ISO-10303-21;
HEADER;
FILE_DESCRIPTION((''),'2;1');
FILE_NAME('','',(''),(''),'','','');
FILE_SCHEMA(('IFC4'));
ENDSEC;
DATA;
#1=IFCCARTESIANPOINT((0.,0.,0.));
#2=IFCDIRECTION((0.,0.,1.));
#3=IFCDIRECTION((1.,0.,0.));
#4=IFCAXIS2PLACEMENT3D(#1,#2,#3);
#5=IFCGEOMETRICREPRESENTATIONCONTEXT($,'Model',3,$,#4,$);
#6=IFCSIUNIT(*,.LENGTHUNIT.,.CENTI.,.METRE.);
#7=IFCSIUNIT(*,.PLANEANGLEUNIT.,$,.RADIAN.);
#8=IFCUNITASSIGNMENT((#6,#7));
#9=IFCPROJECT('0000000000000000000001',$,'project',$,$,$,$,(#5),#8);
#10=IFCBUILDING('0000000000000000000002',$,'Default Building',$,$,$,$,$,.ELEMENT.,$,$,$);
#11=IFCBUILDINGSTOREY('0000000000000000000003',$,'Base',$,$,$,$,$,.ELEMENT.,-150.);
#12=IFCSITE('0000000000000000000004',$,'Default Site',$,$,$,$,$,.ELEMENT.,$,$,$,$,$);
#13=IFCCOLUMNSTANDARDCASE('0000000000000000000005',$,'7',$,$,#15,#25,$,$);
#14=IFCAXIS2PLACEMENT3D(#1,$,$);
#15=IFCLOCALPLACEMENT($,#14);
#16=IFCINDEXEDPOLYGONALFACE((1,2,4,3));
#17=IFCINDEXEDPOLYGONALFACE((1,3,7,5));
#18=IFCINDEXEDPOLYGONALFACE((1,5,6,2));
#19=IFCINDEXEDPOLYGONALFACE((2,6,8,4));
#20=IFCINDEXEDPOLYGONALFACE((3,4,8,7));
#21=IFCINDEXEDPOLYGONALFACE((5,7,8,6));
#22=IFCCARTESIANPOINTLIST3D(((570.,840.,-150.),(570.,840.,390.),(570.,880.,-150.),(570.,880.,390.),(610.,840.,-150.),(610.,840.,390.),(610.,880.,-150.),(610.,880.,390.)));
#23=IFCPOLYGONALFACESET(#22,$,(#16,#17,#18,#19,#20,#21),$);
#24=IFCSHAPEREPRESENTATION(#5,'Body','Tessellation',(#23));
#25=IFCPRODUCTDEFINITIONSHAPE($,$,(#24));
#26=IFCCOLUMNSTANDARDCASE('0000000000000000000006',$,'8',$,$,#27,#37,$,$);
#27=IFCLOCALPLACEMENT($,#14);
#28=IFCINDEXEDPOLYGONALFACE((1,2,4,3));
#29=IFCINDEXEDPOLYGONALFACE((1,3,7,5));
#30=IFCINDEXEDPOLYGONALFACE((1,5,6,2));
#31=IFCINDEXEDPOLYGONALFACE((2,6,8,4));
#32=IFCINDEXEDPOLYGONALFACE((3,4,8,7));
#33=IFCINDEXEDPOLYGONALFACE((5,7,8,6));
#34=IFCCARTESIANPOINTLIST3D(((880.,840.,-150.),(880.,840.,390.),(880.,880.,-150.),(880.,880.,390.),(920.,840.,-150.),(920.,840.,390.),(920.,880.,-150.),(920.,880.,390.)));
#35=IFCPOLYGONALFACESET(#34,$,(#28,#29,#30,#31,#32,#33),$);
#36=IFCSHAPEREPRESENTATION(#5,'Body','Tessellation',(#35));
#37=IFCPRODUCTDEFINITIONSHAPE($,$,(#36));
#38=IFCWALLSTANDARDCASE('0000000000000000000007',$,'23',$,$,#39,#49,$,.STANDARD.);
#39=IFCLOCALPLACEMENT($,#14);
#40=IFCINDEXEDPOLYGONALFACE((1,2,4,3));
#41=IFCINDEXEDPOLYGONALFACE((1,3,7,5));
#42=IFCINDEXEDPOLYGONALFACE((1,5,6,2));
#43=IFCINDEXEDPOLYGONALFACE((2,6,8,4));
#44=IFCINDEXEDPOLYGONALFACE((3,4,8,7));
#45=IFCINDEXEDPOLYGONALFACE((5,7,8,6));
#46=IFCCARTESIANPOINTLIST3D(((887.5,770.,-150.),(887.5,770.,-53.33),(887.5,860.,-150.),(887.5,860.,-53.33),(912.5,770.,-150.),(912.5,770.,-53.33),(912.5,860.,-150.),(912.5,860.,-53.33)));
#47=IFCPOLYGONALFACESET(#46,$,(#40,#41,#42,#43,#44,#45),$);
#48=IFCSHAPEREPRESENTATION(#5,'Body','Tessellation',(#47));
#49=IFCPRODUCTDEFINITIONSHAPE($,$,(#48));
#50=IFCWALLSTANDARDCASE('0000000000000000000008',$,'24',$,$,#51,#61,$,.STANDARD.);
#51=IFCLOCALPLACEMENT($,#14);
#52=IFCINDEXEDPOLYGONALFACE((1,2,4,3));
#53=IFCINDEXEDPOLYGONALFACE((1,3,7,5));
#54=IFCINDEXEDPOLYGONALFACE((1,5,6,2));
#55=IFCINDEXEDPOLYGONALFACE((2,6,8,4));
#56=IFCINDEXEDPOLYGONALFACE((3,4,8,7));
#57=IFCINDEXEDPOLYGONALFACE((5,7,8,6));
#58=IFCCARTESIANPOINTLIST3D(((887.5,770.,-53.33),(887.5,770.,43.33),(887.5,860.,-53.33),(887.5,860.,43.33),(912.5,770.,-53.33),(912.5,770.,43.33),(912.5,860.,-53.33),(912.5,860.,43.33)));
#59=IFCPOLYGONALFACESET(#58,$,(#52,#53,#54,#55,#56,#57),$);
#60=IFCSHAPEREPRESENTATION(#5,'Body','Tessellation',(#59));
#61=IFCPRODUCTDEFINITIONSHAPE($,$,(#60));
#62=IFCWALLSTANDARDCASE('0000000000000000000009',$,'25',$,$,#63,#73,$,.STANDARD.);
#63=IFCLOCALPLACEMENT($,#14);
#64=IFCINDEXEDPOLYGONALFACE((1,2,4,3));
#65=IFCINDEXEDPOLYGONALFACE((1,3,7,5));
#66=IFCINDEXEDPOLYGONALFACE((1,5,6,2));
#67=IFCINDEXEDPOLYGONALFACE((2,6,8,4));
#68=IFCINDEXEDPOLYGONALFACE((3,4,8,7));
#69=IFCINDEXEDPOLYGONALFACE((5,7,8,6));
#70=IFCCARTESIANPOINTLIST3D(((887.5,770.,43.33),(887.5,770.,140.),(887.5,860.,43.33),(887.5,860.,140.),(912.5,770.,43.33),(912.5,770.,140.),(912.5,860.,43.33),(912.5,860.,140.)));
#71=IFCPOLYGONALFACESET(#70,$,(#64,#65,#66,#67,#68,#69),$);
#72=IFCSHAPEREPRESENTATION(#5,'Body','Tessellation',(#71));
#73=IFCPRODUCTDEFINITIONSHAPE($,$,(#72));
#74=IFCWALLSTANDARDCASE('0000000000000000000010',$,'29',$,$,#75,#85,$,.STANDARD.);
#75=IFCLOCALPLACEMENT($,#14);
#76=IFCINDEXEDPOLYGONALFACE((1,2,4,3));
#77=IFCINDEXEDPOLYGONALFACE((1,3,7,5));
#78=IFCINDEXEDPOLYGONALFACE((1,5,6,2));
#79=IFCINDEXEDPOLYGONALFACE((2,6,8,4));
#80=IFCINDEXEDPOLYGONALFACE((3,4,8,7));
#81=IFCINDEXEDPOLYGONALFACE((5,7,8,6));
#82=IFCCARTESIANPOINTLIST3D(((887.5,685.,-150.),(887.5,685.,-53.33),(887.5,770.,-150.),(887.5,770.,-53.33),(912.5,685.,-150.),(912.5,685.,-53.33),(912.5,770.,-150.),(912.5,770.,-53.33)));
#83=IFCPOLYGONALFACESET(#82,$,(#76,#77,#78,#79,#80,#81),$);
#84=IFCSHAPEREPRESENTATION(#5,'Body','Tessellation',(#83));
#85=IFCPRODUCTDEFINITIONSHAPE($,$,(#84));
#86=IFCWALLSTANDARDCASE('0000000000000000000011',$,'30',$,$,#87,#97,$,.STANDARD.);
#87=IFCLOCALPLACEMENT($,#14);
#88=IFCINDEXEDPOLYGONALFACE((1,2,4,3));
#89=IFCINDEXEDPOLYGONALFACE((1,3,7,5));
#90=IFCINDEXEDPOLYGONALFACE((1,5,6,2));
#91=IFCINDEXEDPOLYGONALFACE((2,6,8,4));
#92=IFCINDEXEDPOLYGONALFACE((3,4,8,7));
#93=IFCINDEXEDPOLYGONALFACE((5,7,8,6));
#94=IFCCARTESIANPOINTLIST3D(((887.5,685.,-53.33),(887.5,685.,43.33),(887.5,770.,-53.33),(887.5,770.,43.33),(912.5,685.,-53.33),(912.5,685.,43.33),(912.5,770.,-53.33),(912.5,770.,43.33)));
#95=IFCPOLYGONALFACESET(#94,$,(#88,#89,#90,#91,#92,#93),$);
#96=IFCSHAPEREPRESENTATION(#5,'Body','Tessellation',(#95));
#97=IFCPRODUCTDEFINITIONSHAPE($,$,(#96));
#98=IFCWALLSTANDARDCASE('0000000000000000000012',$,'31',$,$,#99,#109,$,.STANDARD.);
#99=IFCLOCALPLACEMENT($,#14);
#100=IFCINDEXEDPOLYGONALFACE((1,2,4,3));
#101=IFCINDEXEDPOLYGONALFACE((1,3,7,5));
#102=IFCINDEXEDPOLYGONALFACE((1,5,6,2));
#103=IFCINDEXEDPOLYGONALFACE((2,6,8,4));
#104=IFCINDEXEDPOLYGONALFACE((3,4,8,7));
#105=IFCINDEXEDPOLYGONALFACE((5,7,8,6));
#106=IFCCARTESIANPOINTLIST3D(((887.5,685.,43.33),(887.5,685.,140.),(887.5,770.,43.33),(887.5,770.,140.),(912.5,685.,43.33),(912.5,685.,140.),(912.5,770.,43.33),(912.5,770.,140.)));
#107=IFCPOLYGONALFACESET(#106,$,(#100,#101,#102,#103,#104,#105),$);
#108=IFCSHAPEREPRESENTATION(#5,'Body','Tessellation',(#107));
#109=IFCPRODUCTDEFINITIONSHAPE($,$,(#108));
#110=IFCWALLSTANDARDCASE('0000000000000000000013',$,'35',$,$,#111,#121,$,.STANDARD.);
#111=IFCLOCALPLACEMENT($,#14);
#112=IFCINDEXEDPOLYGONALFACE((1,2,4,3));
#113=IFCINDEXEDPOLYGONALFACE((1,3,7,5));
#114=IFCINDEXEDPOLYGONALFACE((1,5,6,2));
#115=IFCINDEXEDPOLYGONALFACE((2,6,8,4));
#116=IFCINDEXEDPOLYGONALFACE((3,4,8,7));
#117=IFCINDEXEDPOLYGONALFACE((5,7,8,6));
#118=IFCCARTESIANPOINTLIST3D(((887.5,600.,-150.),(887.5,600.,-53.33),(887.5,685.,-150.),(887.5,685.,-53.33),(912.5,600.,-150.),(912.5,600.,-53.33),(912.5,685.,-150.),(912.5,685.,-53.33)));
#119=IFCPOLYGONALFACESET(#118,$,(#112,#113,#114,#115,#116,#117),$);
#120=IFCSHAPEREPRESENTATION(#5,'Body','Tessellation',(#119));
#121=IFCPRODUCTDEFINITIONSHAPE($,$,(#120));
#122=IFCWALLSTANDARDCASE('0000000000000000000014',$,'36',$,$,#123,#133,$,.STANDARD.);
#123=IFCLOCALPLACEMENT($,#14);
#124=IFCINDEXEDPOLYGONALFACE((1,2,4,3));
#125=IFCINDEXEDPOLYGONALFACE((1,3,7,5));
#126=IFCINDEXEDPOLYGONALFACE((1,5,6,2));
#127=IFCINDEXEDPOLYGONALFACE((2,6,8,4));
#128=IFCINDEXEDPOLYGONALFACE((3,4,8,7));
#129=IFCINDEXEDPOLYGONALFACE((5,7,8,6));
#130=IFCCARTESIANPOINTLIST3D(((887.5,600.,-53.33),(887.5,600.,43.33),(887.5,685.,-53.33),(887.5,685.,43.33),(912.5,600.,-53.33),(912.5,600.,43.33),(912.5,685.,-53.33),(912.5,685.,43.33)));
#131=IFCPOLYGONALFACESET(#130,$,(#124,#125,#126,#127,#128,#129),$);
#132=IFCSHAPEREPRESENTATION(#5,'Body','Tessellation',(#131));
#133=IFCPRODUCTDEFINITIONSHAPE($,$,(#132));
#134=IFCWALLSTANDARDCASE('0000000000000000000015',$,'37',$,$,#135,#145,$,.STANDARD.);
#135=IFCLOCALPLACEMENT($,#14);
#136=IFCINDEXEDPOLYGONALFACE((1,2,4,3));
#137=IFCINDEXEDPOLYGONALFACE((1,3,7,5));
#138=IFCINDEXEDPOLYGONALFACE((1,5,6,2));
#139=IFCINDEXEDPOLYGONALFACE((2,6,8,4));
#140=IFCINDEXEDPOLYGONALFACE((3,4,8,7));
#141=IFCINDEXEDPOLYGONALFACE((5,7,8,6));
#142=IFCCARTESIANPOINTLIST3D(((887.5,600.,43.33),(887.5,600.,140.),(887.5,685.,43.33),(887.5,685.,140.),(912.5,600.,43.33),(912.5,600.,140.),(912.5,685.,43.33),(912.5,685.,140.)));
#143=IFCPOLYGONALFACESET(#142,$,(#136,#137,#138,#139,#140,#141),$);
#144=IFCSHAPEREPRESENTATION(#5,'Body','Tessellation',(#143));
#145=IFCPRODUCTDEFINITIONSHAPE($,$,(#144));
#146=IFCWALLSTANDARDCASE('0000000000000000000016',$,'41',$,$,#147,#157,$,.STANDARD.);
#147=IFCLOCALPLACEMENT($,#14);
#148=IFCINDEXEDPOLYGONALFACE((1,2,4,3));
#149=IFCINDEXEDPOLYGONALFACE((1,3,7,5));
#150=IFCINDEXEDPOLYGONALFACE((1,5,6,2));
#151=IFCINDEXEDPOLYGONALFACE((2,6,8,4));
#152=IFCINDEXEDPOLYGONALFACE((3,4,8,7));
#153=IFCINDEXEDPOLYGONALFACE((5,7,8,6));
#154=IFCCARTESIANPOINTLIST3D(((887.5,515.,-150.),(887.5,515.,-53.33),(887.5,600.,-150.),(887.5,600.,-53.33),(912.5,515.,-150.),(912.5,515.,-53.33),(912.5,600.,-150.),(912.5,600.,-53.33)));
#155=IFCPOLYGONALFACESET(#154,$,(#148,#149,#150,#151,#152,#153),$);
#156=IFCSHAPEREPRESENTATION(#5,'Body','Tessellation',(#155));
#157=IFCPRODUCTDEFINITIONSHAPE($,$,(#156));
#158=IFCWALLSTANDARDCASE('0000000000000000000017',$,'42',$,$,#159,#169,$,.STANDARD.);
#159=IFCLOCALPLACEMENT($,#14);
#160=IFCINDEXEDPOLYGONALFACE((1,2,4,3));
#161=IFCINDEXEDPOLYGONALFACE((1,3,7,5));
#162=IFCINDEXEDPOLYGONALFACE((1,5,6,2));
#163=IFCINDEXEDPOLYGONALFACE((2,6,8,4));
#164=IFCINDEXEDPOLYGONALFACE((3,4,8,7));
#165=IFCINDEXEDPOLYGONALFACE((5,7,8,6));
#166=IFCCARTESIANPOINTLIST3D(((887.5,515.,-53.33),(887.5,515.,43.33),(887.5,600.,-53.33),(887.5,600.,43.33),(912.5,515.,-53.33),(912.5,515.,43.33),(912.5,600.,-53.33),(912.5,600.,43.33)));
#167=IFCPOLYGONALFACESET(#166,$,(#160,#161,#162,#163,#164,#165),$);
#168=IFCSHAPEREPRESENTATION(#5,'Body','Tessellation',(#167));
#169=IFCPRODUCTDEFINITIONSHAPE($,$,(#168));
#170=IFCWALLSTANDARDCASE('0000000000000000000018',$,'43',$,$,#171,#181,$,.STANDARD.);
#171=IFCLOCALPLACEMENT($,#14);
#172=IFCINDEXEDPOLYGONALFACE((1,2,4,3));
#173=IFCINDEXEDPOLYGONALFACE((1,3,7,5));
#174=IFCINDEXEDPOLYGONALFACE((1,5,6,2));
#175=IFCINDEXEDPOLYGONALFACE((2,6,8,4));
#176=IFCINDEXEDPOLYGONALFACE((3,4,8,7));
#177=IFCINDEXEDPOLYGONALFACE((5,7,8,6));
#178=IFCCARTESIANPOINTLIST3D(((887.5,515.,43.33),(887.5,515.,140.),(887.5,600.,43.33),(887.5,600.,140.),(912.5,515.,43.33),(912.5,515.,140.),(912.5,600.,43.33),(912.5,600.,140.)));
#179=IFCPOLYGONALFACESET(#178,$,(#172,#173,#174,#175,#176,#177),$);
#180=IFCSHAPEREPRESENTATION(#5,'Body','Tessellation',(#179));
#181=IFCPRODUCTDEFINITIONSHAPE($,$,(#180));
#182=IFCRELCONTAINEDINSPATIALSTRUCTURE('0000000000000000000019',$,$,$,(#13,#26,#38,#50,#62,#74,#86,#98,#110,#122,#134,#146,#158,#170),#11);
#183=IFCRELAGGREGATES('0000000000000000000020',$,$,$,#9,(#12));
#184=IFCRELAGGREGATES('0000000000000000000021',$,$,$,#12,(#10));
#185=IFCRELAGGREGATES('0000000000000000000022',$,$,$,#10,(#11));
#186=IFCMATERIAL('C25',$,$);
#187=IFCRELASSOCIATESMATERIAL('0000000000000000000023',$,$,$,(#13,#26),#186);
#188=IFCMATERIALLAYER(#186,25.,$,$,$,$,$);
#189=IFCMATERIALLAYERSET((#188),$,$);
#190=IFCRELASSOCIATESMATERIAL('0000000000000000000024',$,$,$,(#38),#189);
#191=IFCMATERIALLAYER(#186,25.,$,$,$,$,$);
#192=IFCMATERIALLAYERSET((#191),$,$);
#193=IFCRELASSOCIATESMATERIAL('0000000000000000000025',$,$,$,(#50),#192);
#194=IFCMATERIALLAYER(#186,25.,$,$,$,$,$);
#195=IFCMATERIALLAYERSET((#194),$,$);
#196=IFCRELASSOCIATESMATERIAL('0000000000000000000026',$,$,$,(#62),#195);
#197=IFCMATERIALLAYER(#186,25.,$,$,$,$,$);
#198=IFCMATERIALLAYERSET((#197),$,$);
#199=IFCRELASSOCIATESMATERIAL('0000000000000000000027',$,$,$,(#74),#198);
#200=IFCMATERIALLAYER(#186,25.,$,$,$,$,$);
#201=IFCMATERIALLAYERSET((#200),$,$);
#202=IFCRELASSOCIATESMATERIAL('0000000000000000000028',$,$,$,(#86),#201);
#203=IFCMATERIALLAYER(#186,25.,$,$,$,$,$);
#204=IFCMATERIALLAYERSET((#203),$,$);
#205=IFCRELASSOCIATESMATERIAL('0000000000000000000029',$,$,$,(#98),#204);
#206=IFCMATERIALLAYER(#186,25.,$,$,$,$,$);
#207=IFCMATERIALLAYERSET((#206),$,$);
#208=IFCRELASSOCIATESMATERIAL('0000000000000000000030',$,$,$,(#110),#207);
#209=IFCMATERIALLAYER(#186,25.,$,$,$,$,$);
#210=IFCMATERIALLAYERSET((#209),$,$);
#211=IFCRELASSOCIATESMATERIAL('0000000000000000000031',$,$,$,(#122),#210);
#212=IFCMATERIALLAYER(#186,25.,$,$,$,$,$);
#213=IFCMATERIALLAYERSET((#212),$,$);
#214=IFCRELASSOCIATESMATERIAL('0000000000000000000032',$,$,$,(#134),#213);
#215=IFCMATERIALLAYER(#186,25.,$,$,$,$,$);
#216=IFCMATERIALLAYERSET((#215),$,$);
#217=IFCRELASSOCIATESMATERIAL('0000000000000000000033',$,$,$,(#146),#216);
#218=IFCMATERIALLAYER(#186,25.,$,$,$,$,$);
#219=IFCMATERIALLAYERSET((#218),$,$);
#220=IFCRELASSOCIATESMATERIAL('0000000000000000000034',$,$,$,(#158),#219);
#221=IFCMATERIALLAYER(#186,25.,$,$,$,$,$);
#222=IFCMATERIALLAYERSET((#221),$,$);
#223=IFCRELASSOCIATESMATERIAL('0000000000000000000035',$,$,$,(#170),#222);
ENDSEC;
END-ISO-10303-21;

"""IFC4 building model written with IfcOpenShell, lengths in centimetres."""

from ifc_helpers import new_model, si_unit, frame, origin_with_axes, origin_2d_with_axis, place, context, project, spatial, rectangle, extrude, material, layer, layer_set, layer_usage, material_profile, profile_set, profile_usage, element, save


model = new_model("IFC4")

# Units and contexts
model_context = context("Model", 3, world=origin_with_axes())
ifc_project = project(units=[si_unit("LENGTHUNIT", "METRE", prefix="CENTI"), si_unit("PLANEANGLEUNIT", "RADIAN")], contexts=[model_context])

# Site, building, storey
site = spatial("IfcSite", under=ifc_project, Name="Default Site", CompositionType="ELEMENT")
building = spatial("IfcBuilding", under=site, Name="Default Building", CompositionType="ELEMENT")
storey = spatial("IfcBuildingStorey", under=building, Name="Base", CompositionType="ELEMENT", Elevation=-150.0)

# Columns
ifc_material = material(Name="C25")
ifc_material_profile_1 = material_profile(ifc_material, rectangle(XDim=40.0, YDim=40.0, at=origin_2d_with_axis()))
ifc_profile_set_1 = profile_set([ifc_material_profile_1])
ifc_profile_usage_1 = profile_usage(ifc_profile_set_1, cardinal=10)
column_1_placement = place(None, frame((590.0, 860.0, -150.0), z_axis=(0.0, 0.0, 1.0), x_axis=(0.0, -1.0, 0.0)))
element("IfcColumnStandardCase", 1, at=column_1_placement, inside=storey, material=ifc_profile_usage_1, Name="7", context=model_context, shape_type="SweptSolid", body=[
    extrude(rectangle(XDim=40.0, YDim=40.0, at=origin_2d_with_axis()), origin_with_axes(), (0.0, 0.0, 1.0), 540.0),
])
ifc_material_profile_2 = material_profile(ifc_material, rectangle(XDim=40.0, YDim=40.0, at=origin_2d_with_axis()))
ifc_profile_set_2 = profile_set([ifc_material_profile_2])
ifc_profile_usage_2 = profile_usage(ifc_profile_set_2, cardinal=10)
column_2_placement = place(None, frame((900.0, 860.0, -150.0), z_axis=(0.0, 0.0, 1.0), x_axis=(0.0, -1.0, 0.0)))
element("IfcColumnStandardCase", 2, at=column_2_placement, inside=storey, material=ifc_profile_usage_2, Name="8", context=model_context, shape_type="SweptSolid", body=[
    extrude(rectangle(XDim=40.0, YDim=40.0, at=origin_2d_with_axis()), origin_with_axes(), (0.0, 0.0, 1.0), 540.0),
])

# Walls
ifc_layer_1 = layer(ifc_material, 25.0)
ifc_layer_set_1 = layer_set([ifc_layer_1])
ifc_layer_usage_1 = layer_usage(ifc_layer_set_1, "AXIS2", "POSITIVE", -25.0)
wall_1_placement = place(None, frame((900.0, 815.0, -150.0), z_axis=(0.0, 0.0, 1.0), x_axis=(0.0, -1.0, 0.0)))
element("IfcWallStandardCase", 3, at=wall_1_placement, inside=storey, material=ifc_layer_usage_1, Name="23", PredefinedType="STANDARD", context=model_context, shape_type="SweptSolid", body=[
    extrude(rectangle(XDim=90.0, YDim=25.0, at=origin_2d_with_axis()), origin_with_axes(), (0.0, 0.0, 1.0), 96.67),
])
ifc_layer_2 = layer(ifc_material, 25.0)
ifc_layer_set_2 = layer_set([ifc_layer_2])
ifc_layer_usage_2 = layer_usage(ifc_layer_set_2, "AXIS2", "POSITIVE", -25.0)
wall_2_placement = place(None, frame((900.0, 815.0, -53.33), z_axis=(0.0, 0.0, 1.0), x_axis=(0.0, -1.0, 0.0)))
element("IfcWallStandardCase", 4, at=wall_2_placement, inside=storey, material=ifc_layer_usage_2, Name="24", PredefinedType="STANDARD", context=model_context, shape_type="SweptSolid", body=[
    extrude(rectangle(XDim=90.0, YDim=25.0, at=origin_2d_with_axis()), origin_with_axes(), (0.0, 0.0, 1.0), 96.67),
])
ifc_layer_3 = layer(ifc_material, 25.0)
ifc_layer_set_3 = layer_set([ifc_layer_3])
ifc_layer_usage_3 = layer_usage(ifc_layer_set_3, "AXIS2", "POSITIVE", -25.0)
wall_3_placement = place(None, frame((900.0, 815.0, 43.33), z_axis=(0.0, 0.0, 1.0), x_axis=(0.0, -1.0, 0.0)))
element("IfcWallStandardCase", 5, at=wall_3_placement, inside=storey, material=ifc_layer_usage_3, Name="25", PredefinedType="STANDARD", context=model_context, shape_type="SweptSolid", body=[
    extrude(rectangle(XDim=90.0, YDim=25.0, at=origin_2d_with_axis()), origin_with_axes(), (0.0, 0.0, 1.0), 96.67),
])
ifc_layer_4 = layer(ifc_material, 25.0)
ifc_layer_set_4 = layer_set([ifc_layer_4])
ifc_layer_usage_4 = layer_usage(ifc_layer_set_4, "AXIS2", "POSITIVE", -25.0)
wall_4_placement = place(None, frame((900.0, 727.5, -150.0), z_axis=(0.0, 0.0, 1.0), x_axis=(0.0, -1.0, 0.0)))
element("IfcWallStandardCase", 6, at=wall_4_placement, inside=storey, material=ifc_layer_usage_4, Name="29", PredefinedType="STANDARD", context=model_context, shape_type="SweptSolid", body=[
    extrude(rectangle(XDim=85.0, YDim=25.0, at=origin_2d_with_axis()), origin_with_axes(), (0.0, 0.0, 1.0), 96.67),
])
ifc_layer_5 = layer(ifc_material, 25.0)
ifc_layer_set_5 = layer_set([ifc_layer_5])
ifc_layer_usage_5 = layer_usage(ifc_layer_set_5, "AXIS2", "POSITIVE", -25.0)
wall_5_placement = place(None, frame((900.0, 727.5, -53.33), z_axis=(0.0, 0.0, 1.0), x_axis=(0.0, -1.0, 0.0)))
element("IfcWallStandardCase", 7, at=wall_5_placement, inside=storey, material=ifc_layer_usage_5, Name="30", PredefinedType="STANDARD", context=model_context, shape_type="SweptSolid", body=[
    extrude(rectangle(XDim=85.0, YDim=25.0, at=origin_2d_with_axis()), origin_with_axes(), (0.0, 0.0, 1.0), 96.67),
])
ifc_layer_6 = layer(ifc_material, 25.0)
ifc_layer_set_6 = layer_set([ifc_layer_6])
ifc_layer_usage_6 = layer_usage(ifc_layer_set_6, "AXIS2", "POSITIVE", -25.0)
wall_6_placement = place(None, frame((900.0, 727.5, 43.33), z_axis=(0.0, 0.0, 1.0), x_axis=(0.0, -1.0, 0.0)))
element("IfcWallStandardCase", 8, at=wall_6_placement, inside=storey, material=ifc_layer_usage_6, Name="31", PredefinedType="STANDARD", context=model_context, shape_type="SweptSolid", body=[
    extrude(rectangle(XDim=85.0, YDim=25.0, at=origin_2d_with_axis()), origin_with_axes(), (0.0, 0.0, 1.0), 96.67),
])
ifc_layer_7 = layer(ifc_material, 25.0)
ifc_layer_set_7 = layer_set([ifc_layer_7])
ifc_layer_usage_7 = layer_usage(ifc_layer_set_7, "AXIS2", "POSITIVE", -25.0)
wall_7_placement = place(None, frame((900.0, 642.5, -150.0), z_axis=(0.0, 0.0, 1.0), x_axis=(0.0, -1.0, 0.0)))
element("IfcWallStandardCase", 9, at=wall_7_placement, inside=storey, material=ifc_layer_usage_7, Name="35", PredefinedType="STANDARD", context=model_context, shape_type="SweptSolid", body=[
    extrude(rectangle(XDim=85.0, YDim=25.0, at=origin_2d_with_axis()), origin_with_axes(), (0.0, 0.0, 1.0), 96.67),
])
ifc_layer_8 = layer(ifc_material, 25.0)
ifc_layer_set_8 = layer_set([ifc_layer_8])
ifc_layer_usage_8 = layer_usage(ifc_layer_set_8, "AXIS2", "POSITIVE", -25.0)
wall_8_placement = place(None, frame((900.0, 642.5, -53.33), z_axis=(0.0, 0.0, 1.0), x_axis=(0.0, -1.0, 0.0)))
element("IfcWallStandardCase", 10, at=wall_8_placement, inside=storey, material=ifc_layer_usage_8, Name="36", PredefinedType="STANDARD", context=model_context, shape_type="SweptSolid", body=[
    extrude(rectangle(XDim=85.0, YDim=25.0, at=origin_2d_with_axis()), origin_with_axes(), (0.0, 0.0, 1.0), 96.67),
])
ifc_layer_9 = layer(ifc_material, 25.0)
ifc_layer_set_9 = layer_set([ifc_layer_9])
ifc_layer_usage_9 = layer_usage(ifc_layer_set_9, "AXIS2", "POSITIVE", -25.0)
wall_9_placement = place(None, frame((900.0, 642.5, 43.33), z_axis=(0.0, 0.0, 1.0), x_axis=(0.0, -1.0, 0.0)))
element("IfcWallStandardCase", 11, at=wall_9_placement, inside=storey, material=ifc_layer_usage_9, Name="37", PredefinedType="STANDARD", context=model_context, shape_type="SweptSolid", body=[
    extrude(rectangle(XDim=85.0, YDim=25.0, at=origin_2d_with_axis()), origin_with_axes(), (0.0, 0.0, 1.0), 96.67),
])
ifc_layer_10 = layer(ifc_material, 25.0)
ifc_layer_set_10 = layer_set([ifc_layer_10])
ifc_layer_usage_10 = layer_usage(ifc_layer_set_10, "AXIS2", "POSITIVE", -25.0)
wall_10_placement = place(None, frame((900.0, 557.5, -150.0), z_axis=(0.0, 0.0, 1.0), x_axis=(0.0, -1.0, 0.0)))
element("IfcWallStandardCase", 12, at=wall_10_placement, inside=storey, material=ifc_layer_usage_10, Name="41", PredefinedType="STANDARD", context=model_context, shape_type="SweptSolid", body=[
    extrude(rectangle(XDim=85.0, YDim=25.0, at=origin_2d_with_axis()), origin_with_axes(), (0.0, 0.0, 1.0), 96.67),
])
ifc_layer_11 = layer(ifc_material, 25.0)
ifc_layer_set_11 = layer_set([ifc_layer_11])
ifc_layer_usage_11 = layer_usage(ifc_layer_set_11, "AXIS2", "POSITIVE", -25.0)
wall_11_placement = place(None, frame((900.0, 557.5, -53.33), z_axis=(0.0, 0.0, 1.0), x_axis=(0.0, -1.0, 0.0)))
element("IfcWallStandardCase", 13, at=wall_11_placement, inside=storey, material=ifc_layer_usage_11, Name="42", PredefinedType="STANDARD", context=model_context, shape_type="SweptSolid", body=[
    extrude(rectangle(XDim=85.0, YDim=25.0, at=origin_2d_with_axis()), origin_with_axes(), (0.0, 0.0, 1.0), 96.67),
])
ifc_layer_12 = layer(ifc_material, 25.0)
ifc_layer_set_12 = layer_set([ifc_layer_12])
ifc_layer_usage_12 = layer_usage(ifc_layer_set_12, "AXIS2", "POSITIVE", -25.0)
wall_12_placement = place(None, frame((900.0, 557.5, 43.33), z_axis=(0.0, 0.0, 1.0), x_axis=(0.0, -1.0, 0.0)))
element("IfcWallStandardCase", 14, at=wall_12_placement, inside=storey, material=ifc_layer_usage_12, Name="43", PredefinedType="STANDARD", context=model_context, shape_type="SweptSolid", body=[
    extrude(rectangle(XDim=85.0, YDim=25.0, at=origin_2d_with_axis()), origin_with_axes(), (0.0, 0.0, 1.0), 96.67),
])

save(model, "model.ifc")
